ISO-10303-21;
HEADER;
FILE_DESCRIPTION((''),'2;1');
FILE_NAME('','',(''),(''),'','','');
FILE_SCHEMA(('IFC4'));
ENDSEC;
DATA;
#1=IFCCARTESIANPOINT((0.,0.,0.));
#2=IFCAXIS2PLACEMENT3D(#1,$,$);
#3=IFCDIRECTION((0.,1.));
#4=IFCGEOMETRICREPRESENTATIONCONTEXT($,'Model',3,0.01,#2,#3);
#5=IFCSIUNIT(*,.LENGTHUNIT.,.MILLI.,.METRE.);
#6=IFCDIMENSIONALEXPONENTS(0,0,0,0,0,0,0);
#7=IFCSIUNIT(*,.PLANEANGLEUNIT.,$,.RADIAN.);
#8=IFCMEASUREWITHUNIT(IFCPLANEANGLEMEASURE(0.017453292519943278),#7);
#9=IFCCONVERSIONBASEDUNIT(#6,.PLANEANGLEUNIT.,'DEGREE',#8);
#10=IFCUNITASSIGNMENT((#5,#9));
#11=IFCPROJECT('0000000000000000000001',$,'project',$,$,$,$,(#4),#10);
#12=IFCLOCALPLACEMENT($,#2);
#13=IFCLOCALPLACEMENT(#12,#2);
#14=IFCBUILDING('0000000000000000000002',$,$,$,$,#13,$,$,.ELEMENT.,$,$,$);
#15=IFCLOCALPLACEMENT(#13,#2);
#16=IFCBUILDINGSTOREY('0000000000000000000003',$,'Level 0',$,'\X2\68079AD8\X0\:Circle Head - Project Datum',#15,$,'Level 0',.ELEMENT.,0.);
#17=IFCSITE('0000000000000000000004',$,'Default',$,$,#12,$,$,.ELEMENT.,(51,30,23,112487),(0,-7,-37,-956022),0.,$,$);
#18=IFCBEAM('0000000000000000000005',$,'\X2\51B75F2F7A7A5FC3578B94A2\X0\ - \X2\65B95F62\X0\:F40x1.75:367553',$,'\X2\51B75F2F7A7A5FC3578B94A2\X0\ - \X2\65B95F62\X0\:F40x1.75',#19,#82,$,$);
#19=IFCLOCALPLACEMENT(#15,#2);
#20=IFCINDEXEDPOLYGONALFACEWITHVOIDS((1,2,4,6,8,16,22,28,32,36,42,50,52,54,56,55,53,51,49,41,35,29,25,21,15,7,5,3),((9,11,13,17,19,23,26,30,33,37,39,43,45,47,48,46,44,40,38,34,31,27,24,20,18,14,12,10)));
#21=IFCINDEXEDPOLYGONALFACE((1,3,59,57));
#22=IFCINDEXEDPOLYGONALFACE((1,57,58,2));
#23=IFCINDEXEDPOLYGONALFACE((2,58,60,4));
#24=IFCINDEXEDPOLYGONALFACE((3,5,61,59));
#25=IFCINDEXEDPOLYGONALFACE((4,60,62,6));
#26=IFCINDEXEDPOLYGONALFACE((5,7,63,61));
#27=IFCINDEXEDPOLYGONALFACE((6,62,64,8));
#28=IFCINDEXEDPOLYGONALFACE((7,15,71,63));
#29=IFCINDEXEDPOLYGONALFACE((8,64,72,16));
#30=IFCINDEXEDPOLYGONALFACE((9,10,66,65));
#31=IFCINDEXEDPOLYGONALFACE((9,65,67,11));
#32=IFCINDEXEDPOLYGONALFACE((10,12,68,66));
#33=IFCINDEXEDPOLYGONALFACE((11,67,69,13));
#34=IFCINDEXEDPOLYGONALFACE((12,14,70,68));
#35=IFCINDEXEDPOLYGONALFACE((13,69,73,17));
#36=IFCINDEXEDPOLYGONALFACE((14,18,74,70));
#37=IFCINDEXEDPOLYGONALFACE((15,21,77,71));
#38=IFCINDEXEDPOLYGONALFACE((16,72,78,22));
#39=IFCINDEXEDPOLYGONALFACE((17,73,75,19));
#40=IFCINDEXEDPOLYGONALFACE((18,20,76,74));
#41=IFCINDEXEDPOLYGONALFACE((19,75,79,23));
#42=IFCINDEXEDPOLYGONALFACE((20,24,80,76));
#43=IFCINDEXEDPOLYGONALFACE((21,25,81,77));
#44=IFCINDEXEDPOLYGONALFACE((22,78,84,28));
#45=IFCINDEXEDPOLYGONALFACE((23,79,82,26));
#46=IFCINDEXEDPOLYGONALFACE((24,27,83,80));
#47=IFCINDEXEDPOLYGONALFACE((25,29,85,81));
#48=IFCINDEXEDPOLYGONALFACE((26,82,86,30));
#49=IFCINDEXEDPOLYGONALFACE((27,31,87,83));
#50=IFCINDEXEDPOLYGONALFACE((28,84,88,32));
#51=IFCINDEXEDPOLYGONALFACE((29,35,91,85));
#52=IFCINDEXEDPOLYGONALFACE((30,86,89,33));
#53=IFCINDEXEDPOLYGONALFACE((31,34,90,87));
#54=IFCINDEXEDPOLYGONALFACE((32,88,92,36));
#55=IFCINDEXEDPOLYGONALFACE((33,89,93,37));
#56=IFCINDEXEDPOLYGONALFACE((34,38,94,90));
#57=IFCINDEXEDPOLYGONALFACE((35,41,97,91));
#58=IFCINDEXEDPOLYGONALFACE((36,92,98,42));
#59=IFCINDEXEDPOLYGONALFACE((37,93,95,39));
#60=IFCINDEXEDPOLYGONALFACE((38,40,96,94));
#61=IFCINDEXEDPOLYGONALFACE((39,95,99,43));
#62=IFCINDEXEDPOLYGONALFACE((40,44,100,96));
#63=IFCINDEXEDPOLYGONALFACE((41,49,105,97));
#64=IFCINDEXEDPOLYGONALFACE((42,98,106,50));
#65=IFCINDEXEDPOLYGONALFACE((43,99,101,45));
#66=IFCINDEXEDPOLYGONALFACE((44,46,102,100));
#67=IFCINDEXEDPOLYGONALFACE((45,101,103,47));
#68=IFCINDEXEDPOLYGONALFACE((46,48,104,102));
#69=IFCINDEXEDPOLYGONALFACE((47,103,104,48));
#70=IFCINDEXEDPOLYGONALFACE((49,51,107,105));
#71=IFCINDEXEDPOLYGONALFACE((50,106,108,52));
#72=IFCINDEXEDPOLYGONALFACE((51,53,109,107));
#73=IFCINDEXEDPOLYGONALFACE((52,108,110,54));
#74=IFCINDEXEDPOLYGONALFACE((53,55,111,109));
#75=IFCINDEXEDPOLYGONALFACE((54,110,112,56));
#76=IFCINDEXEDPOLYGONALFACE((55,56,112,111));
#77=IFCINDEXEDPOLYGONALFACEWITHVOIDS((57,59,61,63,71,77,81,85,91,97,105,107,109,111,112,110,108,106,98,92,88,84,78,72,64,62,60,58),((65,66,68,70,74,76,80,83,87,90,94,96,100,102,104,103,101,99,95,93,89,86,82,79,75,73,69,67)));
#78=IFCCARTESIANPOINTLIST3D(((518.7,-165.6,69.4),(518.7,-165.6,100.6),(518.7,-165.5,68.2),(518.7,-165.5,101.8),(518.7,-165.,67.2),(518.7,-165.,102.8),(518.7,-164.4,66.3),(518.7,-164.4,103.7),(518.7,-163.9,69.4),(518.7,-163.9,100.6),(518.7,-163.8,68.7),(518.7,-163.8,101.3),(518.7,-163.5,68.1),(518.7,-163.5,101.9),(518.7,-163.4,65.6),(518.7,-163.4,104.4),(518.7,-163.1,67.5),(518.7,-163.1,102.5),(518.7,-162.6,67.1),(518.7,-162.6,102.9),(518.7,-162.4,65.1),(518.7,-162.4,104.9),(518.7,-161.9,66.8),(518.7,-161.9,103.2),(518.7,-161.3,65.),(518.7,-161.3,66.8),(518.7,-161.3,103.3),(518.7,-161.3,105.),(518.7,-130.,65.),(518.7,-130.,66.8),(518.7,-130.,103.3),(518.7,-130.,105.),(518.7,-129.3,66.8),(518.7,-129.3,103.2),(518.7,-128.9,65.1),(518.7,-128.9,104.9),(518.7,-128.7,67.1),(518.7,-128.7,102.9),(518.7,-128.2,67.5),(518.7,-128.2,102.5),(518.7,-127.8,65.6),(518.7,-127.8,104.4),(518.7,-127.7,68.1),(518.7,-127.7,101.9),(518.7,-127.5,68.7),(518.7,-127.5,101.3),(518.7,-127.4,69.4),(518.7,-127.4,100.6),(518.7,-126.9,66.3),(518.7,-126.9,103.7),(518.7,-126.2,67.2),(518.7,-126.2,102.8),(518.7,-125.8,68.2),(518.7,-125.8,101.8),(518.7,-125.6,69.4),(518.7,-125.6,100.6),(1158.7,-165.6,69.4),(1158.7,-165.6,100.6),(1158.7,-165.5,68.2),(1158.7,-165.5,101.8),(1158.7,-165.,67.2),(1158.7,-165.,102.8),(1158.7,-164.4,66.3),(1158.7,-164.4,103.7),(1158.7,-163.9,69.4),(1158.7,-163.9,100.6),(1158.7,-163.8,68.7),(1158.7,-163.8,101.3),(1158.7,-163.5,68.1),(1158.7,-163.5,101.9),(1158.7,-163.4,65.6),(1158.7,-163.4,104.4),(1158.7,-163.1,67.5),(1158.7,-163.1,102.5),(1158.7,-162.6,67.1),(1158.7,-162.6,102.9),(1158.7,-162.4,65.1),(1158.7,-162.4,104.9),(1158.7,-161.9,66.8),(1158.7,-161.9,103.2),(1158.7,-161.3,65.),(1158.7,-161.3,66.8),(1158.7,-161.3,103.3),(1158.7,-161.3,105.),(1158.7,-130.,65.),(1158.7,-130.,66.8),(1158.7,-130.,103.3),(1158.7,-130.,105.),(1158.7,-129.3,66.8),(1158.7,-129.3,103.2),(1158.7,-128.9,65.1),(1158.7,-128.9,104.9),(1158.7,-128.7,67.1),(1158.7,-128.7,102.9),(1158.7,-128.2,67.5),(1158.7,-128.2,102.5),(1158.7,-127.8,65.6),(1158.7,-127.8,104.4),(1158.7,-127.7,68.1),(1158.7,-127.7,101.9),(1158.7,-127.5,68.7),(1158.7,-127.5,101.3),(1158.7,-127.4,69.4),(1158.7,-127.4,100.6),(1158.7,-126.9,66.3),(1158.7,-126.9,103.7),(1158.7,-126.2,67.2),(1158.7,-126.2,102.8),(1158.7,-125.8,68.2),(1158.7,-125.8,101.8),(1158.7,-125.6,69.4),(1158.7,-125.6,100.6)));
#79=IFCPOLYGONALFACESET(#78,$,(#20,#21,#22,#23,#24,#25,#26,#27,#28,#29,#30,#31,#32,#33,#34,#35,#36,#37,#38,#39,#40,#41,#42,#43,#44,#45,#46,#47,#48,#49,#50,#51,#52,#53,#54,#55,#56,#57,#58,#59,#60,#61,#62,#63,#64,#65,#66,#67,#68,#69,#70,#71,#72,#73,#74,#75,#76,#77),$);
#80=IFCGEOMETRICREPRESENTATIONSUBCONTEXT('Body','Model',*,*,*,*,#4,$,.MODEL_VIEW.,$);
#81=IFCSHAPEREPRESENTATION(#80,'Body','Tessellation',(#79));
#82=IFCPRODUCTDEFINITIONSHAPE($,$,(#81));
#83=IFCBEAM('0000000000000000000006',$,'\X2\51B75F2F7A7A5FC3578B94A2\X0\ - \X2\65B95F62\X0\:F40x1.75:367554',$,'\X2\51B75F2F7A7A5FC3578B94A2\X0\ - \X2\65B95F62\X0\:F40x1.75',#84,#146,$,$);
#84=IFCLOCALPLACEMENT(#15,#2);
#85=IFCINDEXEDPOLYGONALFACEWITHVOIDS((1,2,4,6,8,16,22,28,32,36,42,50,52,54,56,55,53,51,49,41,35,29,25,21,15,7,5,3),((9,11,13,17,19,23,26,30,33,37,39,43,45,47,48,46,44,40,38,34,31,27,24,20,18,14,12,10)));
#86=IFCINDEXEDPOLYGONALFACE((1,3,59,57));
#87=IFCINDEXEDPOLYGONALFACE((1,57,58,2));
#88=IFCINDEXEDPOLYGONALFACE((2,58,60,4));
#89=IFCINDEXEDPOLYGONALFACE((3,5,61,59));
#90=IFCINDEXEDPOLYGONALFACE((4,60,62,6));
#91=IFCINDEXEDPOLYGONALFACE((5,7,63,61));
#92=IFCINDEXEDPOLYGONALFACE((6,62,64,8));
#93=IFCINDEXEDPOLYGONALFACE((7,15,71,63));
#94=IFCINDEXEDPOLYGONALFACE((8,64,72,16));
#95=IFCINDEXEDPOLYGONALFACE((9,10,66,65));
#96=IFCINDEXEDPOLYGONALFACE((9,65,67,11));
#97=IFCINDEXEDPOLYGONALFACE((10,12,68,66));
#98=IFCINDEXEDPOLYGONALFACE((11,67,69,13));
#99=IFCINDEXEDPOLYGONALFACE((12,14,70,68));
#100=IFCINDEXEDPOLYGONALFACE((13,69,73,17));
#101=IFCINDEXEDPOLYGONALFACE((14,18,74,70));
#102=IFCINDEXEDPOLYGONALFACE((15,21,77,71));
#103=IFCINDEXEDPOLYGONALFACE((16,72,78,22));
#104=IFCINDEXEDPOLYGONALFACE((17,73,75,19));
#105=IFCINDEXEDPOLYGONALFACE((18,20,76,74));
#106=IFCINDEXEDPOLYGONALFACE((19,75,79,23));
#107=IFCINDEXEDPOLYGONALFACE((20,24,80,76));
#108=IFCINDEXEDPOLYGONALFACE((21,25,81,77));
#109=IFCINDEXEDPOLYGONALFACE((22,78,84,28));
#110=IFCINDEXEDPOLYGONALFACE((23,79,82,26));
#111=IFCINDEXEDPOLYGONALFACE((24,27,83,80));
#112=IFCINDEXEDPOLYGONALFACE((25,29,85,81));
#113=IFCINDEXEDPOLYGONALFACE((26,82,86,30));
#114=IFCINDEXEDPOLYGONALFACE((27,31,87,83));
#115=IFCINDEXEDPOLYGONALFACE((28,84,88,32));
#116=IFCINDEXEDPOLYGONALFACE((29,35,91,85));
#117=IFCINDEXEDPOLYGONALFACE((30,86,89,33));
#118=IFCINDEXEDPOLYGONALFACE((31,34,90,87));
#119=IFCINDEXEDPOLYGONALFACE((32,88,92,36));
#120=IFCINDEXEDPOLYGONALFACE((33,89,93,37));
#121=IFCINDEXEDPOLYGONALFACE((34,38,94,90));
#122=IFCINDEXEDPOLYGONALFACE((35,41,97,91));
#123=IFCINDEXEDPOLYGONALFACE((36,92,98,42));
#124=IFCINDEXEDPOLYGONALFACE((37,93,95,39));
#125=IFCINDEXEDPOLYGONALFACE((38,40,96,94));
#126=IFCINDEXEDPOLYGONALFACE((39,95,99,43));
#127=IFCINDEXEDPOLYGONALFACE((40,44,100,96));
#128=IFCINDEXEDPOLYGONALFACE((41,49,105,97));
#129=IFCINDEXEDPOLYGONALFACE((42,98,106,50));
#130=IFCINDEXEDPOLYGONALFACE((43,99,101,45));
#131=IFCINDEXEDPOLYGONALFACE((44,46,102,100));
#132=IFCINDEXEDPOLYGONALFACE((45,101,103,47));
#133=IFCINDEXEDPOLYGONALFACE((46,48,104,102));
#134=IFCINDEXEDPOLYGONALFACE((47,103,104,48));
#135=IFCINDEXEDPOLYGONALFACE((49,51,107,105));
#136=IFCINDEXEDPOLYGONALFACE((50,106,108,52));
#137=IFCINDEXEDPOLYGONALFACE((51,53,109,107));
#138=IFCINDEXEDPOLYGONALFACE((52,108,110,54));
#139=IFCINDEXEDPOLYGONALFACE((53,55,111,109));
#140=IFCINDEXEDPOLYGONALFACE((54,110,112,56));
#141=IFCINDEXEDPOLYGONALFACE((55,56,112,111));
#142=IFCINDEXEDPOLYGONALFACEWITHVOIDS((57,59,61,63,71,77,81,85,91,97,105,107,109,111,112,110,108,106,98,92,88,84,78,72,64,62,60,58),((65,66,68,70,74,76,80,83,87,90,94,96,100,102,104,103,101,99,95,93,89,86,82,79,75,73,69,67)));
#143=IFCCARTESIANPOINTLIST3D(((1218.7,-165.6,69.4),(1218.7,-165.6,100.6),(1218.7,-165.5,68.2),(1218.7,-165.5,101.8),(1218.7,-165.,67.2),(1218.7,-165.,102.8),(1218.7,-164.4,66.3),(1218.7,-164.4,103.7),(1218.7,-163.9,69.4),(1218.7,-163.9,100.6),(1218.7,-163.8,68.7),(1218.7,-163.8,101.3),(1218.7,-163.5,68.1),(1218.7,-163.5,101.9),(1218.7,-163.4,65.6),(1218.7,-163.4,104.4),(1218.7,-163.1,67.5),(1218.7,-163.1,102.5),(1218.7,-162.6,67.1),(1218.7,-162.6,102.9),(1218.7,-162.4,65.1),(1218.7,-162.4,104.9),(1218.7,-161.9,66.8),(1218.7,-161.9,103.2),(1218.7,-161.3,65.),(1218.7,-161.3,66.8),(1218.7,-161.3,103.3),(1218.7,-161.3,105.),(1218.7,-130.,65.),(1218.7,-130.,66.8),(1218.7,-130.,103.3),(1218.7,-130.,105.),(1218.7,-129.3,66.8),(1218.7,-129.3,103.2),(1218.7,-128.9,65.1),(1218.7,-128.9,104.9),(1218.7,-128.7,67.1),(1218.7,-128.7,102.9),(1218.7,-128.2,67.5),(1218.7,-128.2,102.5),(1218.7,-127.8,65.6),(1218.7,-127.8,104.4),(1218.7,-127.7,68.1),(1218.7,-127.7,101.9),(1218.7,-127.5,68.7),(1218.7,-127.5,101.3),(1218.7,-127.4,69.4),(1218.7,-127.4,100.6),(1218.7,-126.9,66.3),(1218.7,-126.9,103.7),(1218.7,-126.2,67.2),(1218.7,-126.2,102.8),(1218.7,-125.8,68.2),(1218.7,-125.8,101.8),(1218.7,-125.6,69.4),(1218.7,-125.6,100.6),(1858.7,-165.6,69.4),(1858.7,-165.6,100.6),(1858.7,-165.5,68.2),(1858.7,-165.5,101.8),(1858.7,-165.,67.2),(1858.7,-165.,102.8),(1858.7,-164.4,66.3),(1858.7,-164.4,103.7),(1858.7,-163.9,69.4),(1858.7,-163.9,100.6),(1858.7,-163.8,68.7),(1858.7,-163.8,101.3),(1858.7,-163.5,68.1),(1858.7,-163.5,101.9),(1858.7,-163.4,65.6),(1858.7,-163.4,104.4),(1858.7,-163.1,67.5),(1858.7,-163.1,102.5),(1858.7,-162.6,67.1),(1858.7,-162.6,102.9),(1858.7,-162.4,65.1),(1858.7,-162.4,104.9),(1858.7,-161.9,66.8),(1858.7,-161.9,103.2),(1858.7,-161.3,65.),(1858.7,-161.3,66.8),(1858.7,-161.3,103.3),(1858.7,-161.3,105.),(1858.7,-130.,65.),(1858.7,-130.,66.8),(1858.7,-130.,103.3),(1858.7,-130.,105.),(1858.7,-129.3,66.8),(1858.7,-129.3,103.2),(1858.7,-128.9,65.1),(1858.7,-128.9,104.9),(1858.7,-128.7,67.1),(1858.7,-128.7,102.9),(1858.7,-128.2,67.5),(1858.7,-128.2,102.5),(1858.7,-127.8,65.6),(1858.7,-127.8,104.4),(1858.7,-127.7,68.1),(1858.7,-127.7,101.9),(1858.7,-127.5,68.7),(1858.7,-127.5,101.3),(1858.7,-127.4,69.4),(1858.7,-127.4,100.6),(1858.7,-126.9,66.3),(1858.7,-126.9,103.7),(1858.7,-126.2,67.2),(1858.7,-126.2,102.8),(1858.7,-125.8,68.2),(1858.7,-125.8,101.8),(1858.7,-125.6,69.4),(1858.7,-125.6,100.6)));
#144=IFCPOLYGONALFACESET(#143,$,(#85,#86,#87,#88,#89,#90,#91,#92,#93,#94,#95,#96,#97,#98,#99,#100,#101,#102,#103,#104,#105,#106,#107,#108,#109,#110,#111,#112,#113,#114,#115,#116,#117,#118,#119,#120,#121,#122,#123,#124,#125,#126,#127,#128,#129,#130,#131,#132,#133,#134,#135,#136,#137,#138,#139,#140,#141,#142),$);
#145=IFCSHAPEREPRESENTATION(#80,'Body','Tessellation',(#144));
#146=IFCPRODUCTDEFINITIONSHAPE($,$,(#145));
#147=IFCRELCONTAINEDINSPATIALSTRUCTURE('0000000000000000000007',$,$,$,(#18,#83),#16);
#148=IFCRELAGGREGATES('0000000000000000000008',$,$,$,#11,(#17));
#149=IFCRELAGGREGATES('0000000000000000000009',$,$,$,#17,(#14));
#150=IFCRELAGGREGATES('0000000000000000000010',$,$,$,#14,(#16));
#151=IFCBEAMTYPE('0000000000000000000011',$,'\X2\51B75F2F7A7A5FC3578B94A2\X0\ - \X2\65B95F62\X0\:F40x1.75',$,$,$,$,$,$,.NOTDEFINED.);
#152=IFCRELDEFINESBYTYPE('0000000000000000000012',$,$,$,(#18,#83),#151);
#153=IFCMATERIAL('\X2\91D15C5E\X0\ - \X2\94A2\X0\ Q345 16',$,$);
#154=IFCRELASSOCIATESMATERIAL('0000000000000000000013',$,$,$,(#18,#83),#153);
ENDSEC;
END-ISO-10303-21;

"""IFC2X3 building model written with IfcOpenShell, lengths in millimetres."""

from ifc_helpers import new_model, entity, si_unit, converted_unit, direction, frame, frame_2d, origin, place, context, subcontext, project, spatial, polyline, circle_curve, parameter, trimmed, segment, composite_curve, outline, extrude, material, type_object, element, save


model = new_model("IFC2X3")

# Units and contexts
model_context = context("Model", 3, precision=0.01, world=origin(), true_north=direction((0.0, 1.0)))
body_context = subcontext(model_context, "Body", "Model", "MODEL_VIEW")
ifc_project = project(units=[si_unit("LENGTHUNIT", "METRE", prefix="MILLI"), converted_unit("PLANEANGLEUNIT", "DEGREE", entity("IfcPlaneAngleMeasure", 0.017453292519943278), si_unit("PLANEANGLEUNIT", "RADIAN"), dimensions=[0, 0, 0, 0, 0, 0, 0])], contexts=[model_context])

# Site, building, storey
site_placement = place(None, origin())
site = spatial("IfcSite", under=ifc_project, at=site_placement, Name="Default", CompositionType="ELEMENT", RefLatitude=(51, 30, 23, 112487), RefLongitude=(0, -7, -37, -956022), RefElevation=0.0)
building_placement = place(site_placement, origin())
building = spatial("IfcBuilding", under=site, at=building_placement, CompositionType="ELEMENT")
storey_placement = place(building_placement, origin())
storey = spatial("IfcBuildingStorey", under=building, at=storey_placement, Name="Level 0", ObjectType="标高:Circle Head - Project Datum", LongName="Level 0", CompositionType="ELEMENT", Elevation=0.0)

# Beams
ifc_material_1 = material(Name="金属 - 钢 Q345 16")
beam_type_1 = type_object("IfcBeamType", Name="冷弯空心型钢 - 方形:F40x1.75", PredefinedType="NOTDEFINED")
beam_1_placement = place(storey_placement, frame((553.7, -145.6, 105.0)))
element("IfcBeam", 1, at=beam_1_placement, inside=storey, type_object=beam_type_1, material=ifc_material_1, Name="冷弯空心型钢 - 方形:F40x1.75:367553", ObjectType="冷弯空心型钢 - 方形:F40x1.75", context=body_context, shape_type="SweptSolid", body=[
    extrude(outline(composite_curve([segment(trimmed(circle_curve(frame_2d((-15.6, 15.6), x_axis=(1.0, 0.0)), 4.4), [parameter(90.0)], [parameter(180.0)], True, "PARAMETER"), True, "CONTINUOUS"), segment(polyline([(-20.0, 15.6), (-20.0, -15.6)]), True, "CONTINUOUS"), segment(trimmed(circle_curve(frame_2d((-15.6, -15.6), x_axis=(1.0, 0.0)), 4.4), [parameter(180.0)], [parameter(270.0)], True, "PARAMETER"), True, "CONTINUOUS"), segment(polyline([(-15.6, -20.0), (15.6, -20.0)]), True, "CONTINUOUS"), segment(trimmed(circle_curve(frame_2d((15.6, -15.6), x_axis=(1.0, 0.0)), 4.4), [parameter(270.0)], [parameter(0.0)], True, "PARAMETER"), True, "CONTINUOUS"), segment(polyline([(20.0, -15.6), (20.0, 15.6)]), True, "CONTINUOUS"), segment(trimmed(circle_curve(frame_2d((15.6, 15.6), x_axis=(1.0, 0.0)), 4.4), [parameter(0.0)], [parameter(90.0)], True, "PARAMETER"), True, "CONTINUOUS"), segment(polyline([(15.6, 20.0), (-15.6, 20.0)]), True, "CONTINUOUS")], self_intersect=False), holes=[composite_curve([segment(polyline([(-15.6, 18.3), (15.6, 18.3)]), True, "CONTINUOUS"), segment(trimmed(circle_curve(frame_2d((15.6, 15.6), x_axis=(1.0, 0.0)), 2.6), [parameter(0.0)], [parameter(90.0)], True, "PARAMETER"), False, "CONTINUOUS"), segment(polyline([(18.2, 15.6), (18.2, -15.6)]), True, "CONTINUOUS"), segment(trimmed(circle_curve(frame_2d((15.6, -15.6), x_axis=(1.0, 0.0)), 2.6), [parameter(270.0)], [parameter(360.0)], True, "PARAMETER"), False, "CONTINUOUS"), segment(polyline([(15.6, -18.2), (-15.6, -18.2)]), True, "CONTINUOUS"), segment(trimmed(circle_curve(frame_2d((-15.6, -15.6), x_axis=(1.0, 0.0)), 2.6), [parameter(180.0)], [parameter(270.0)], True, "PARAMETER"), False, "CONTINUOUS"), segment(polyline([(-18.3, -15.6), (-18.3, 15.6)]), True, "CONTINUOUS"), segment(trimmed(circle_curve(frame_2d((-15.6, 15.6), x_axis=(1.0, 0.0)), 2.6), [parameter(90.0)], [parameter(180.0)], True, "PARAMETER"), False, "CONTINUOUS")], self_intersect=False)]), frame((-35.0, 0.0, -20.0), z_axis=(1.0, 0.0, 0.0), x_axis=(0.0, 1.0, 0.0)), (0.0, 0.0, 1.0), 640.0),
])
beam_2_placement = place(storey_placement, frame((1253.7, -145.6, 105.0)))
element("IfcBeam", 2, at=beam_2_placement, inside=storey, type_object=beam_type_1, material=ifc_material_1, Name="冷弯空心型钢 - 方形:F40x1.75:367554", ObjectType="冷弯空心型钢 - 方形:F40x1.75", context=body_context, shape_type="SweptSolid", body=[
    extrude(outline(composite_curve([segment(trimmed(circle_curve(frame_2d((-15.6, 15.6), x_axis=(1.0, 0.0)), 4.4), [parameter(90.0)], [parameter(180.0)], True, "PARAMETER"), True, "CONTINUOUS"), segment(polyline([(-20.0, 15.6), (-20.0, -15.6)]), True, "CONTINUOUS"), segment(trimmed(circle_curve(frame_2d((-15.6, -15.6), x_axis=(1.0, 0.0)), 4.4), [parameter(180.0)], [parameter(270.0)], True, "PARAMETER"), True, "CONTINUOUS"), segment(polyline([(-15.6, -20.0), (15.6, -20.0)]), True, "CONTINUOUS"), segment(trimmed(circle_curve(frame_2d((15.6, -15.6), x_axis=(1.0, 0.0)), 4.4), [parameter(270.0)], [parameter(0.0)], True, "PARAMETER"), True, "CONTINUOUS"), segment(polyline([(20.0, -15.6), (20.0, 15.6)]), True, "CONTINUOUS"), segment(trimmed(circle_curve(frame_2d((15.6, 15.6), x_axis=(1.0, 0.0)), 4.4), [parameter(0.0)], [parameter(90.0)], True, "PARAMETER"), True, "CONTINUOUS"), segment(polyline([(15.6, 20.0), (-15.6, 20.0)]), True, "CONTINUOUS")], self_intersect=False), holes=[composite_curve([segment(polyline([(-15.6, 18.3), (15.6, 18.3)]), True, "CONTINUOUS"), segment(trimmed(circle_curve(frame_2d((15.6, 15.6), x_axis=(1.0, 0.0)), 2.6), [parameter(0.0)], [parameter(90.0)], True, "PARAMETER"), False, "CONTINUOUS"), segment(polyline([(18.2, 15.6), (18.2, -15.6)]), True, "CONTINUOUS"), segment(trimmed(circle_curve(frame_2d((15.6, -15.6), x_axis=(1.0, 0.0)), 2.6), [parameter(270.0)], [parameter(360.0)], True, "PARAMETER"), False, "CONTINUOUS"), segment(polyline([(15.6, -18.2), (-15.6, -18.2)]), True, "CONTINUOUS"), segment(trimmed(circle_curve(frame_2d((-15.6, -15.6), x_axis=(1.0, 0.0)), 2.6), [parameter(180.0)], [parameter(270.0)], True, "PARAMETER"), False, "CONTINUOUS"), segment(polyline([(-18.3, -15.6), (-18.3, 15.6)]), True, "CONTINUOUS"), segment(trimmed(circle_curve(frame_2d((-15.6, 15.6), x_axis=(1.0, 0.0)), 2.6), [parameter(90.0)], [parameter(180.0)], True, "PARAMETER"), False, "CONTINUOUS")], self_intersect=False)]), frame((-35.0, 0.0, -20.0), z_axis=(1.0, 0.0, 0.0), x_axis=(0.0, 1.0, 0.0)), (0.0, 0.0, 1.0), 640.0),
])

save(model, "model.ifc")
